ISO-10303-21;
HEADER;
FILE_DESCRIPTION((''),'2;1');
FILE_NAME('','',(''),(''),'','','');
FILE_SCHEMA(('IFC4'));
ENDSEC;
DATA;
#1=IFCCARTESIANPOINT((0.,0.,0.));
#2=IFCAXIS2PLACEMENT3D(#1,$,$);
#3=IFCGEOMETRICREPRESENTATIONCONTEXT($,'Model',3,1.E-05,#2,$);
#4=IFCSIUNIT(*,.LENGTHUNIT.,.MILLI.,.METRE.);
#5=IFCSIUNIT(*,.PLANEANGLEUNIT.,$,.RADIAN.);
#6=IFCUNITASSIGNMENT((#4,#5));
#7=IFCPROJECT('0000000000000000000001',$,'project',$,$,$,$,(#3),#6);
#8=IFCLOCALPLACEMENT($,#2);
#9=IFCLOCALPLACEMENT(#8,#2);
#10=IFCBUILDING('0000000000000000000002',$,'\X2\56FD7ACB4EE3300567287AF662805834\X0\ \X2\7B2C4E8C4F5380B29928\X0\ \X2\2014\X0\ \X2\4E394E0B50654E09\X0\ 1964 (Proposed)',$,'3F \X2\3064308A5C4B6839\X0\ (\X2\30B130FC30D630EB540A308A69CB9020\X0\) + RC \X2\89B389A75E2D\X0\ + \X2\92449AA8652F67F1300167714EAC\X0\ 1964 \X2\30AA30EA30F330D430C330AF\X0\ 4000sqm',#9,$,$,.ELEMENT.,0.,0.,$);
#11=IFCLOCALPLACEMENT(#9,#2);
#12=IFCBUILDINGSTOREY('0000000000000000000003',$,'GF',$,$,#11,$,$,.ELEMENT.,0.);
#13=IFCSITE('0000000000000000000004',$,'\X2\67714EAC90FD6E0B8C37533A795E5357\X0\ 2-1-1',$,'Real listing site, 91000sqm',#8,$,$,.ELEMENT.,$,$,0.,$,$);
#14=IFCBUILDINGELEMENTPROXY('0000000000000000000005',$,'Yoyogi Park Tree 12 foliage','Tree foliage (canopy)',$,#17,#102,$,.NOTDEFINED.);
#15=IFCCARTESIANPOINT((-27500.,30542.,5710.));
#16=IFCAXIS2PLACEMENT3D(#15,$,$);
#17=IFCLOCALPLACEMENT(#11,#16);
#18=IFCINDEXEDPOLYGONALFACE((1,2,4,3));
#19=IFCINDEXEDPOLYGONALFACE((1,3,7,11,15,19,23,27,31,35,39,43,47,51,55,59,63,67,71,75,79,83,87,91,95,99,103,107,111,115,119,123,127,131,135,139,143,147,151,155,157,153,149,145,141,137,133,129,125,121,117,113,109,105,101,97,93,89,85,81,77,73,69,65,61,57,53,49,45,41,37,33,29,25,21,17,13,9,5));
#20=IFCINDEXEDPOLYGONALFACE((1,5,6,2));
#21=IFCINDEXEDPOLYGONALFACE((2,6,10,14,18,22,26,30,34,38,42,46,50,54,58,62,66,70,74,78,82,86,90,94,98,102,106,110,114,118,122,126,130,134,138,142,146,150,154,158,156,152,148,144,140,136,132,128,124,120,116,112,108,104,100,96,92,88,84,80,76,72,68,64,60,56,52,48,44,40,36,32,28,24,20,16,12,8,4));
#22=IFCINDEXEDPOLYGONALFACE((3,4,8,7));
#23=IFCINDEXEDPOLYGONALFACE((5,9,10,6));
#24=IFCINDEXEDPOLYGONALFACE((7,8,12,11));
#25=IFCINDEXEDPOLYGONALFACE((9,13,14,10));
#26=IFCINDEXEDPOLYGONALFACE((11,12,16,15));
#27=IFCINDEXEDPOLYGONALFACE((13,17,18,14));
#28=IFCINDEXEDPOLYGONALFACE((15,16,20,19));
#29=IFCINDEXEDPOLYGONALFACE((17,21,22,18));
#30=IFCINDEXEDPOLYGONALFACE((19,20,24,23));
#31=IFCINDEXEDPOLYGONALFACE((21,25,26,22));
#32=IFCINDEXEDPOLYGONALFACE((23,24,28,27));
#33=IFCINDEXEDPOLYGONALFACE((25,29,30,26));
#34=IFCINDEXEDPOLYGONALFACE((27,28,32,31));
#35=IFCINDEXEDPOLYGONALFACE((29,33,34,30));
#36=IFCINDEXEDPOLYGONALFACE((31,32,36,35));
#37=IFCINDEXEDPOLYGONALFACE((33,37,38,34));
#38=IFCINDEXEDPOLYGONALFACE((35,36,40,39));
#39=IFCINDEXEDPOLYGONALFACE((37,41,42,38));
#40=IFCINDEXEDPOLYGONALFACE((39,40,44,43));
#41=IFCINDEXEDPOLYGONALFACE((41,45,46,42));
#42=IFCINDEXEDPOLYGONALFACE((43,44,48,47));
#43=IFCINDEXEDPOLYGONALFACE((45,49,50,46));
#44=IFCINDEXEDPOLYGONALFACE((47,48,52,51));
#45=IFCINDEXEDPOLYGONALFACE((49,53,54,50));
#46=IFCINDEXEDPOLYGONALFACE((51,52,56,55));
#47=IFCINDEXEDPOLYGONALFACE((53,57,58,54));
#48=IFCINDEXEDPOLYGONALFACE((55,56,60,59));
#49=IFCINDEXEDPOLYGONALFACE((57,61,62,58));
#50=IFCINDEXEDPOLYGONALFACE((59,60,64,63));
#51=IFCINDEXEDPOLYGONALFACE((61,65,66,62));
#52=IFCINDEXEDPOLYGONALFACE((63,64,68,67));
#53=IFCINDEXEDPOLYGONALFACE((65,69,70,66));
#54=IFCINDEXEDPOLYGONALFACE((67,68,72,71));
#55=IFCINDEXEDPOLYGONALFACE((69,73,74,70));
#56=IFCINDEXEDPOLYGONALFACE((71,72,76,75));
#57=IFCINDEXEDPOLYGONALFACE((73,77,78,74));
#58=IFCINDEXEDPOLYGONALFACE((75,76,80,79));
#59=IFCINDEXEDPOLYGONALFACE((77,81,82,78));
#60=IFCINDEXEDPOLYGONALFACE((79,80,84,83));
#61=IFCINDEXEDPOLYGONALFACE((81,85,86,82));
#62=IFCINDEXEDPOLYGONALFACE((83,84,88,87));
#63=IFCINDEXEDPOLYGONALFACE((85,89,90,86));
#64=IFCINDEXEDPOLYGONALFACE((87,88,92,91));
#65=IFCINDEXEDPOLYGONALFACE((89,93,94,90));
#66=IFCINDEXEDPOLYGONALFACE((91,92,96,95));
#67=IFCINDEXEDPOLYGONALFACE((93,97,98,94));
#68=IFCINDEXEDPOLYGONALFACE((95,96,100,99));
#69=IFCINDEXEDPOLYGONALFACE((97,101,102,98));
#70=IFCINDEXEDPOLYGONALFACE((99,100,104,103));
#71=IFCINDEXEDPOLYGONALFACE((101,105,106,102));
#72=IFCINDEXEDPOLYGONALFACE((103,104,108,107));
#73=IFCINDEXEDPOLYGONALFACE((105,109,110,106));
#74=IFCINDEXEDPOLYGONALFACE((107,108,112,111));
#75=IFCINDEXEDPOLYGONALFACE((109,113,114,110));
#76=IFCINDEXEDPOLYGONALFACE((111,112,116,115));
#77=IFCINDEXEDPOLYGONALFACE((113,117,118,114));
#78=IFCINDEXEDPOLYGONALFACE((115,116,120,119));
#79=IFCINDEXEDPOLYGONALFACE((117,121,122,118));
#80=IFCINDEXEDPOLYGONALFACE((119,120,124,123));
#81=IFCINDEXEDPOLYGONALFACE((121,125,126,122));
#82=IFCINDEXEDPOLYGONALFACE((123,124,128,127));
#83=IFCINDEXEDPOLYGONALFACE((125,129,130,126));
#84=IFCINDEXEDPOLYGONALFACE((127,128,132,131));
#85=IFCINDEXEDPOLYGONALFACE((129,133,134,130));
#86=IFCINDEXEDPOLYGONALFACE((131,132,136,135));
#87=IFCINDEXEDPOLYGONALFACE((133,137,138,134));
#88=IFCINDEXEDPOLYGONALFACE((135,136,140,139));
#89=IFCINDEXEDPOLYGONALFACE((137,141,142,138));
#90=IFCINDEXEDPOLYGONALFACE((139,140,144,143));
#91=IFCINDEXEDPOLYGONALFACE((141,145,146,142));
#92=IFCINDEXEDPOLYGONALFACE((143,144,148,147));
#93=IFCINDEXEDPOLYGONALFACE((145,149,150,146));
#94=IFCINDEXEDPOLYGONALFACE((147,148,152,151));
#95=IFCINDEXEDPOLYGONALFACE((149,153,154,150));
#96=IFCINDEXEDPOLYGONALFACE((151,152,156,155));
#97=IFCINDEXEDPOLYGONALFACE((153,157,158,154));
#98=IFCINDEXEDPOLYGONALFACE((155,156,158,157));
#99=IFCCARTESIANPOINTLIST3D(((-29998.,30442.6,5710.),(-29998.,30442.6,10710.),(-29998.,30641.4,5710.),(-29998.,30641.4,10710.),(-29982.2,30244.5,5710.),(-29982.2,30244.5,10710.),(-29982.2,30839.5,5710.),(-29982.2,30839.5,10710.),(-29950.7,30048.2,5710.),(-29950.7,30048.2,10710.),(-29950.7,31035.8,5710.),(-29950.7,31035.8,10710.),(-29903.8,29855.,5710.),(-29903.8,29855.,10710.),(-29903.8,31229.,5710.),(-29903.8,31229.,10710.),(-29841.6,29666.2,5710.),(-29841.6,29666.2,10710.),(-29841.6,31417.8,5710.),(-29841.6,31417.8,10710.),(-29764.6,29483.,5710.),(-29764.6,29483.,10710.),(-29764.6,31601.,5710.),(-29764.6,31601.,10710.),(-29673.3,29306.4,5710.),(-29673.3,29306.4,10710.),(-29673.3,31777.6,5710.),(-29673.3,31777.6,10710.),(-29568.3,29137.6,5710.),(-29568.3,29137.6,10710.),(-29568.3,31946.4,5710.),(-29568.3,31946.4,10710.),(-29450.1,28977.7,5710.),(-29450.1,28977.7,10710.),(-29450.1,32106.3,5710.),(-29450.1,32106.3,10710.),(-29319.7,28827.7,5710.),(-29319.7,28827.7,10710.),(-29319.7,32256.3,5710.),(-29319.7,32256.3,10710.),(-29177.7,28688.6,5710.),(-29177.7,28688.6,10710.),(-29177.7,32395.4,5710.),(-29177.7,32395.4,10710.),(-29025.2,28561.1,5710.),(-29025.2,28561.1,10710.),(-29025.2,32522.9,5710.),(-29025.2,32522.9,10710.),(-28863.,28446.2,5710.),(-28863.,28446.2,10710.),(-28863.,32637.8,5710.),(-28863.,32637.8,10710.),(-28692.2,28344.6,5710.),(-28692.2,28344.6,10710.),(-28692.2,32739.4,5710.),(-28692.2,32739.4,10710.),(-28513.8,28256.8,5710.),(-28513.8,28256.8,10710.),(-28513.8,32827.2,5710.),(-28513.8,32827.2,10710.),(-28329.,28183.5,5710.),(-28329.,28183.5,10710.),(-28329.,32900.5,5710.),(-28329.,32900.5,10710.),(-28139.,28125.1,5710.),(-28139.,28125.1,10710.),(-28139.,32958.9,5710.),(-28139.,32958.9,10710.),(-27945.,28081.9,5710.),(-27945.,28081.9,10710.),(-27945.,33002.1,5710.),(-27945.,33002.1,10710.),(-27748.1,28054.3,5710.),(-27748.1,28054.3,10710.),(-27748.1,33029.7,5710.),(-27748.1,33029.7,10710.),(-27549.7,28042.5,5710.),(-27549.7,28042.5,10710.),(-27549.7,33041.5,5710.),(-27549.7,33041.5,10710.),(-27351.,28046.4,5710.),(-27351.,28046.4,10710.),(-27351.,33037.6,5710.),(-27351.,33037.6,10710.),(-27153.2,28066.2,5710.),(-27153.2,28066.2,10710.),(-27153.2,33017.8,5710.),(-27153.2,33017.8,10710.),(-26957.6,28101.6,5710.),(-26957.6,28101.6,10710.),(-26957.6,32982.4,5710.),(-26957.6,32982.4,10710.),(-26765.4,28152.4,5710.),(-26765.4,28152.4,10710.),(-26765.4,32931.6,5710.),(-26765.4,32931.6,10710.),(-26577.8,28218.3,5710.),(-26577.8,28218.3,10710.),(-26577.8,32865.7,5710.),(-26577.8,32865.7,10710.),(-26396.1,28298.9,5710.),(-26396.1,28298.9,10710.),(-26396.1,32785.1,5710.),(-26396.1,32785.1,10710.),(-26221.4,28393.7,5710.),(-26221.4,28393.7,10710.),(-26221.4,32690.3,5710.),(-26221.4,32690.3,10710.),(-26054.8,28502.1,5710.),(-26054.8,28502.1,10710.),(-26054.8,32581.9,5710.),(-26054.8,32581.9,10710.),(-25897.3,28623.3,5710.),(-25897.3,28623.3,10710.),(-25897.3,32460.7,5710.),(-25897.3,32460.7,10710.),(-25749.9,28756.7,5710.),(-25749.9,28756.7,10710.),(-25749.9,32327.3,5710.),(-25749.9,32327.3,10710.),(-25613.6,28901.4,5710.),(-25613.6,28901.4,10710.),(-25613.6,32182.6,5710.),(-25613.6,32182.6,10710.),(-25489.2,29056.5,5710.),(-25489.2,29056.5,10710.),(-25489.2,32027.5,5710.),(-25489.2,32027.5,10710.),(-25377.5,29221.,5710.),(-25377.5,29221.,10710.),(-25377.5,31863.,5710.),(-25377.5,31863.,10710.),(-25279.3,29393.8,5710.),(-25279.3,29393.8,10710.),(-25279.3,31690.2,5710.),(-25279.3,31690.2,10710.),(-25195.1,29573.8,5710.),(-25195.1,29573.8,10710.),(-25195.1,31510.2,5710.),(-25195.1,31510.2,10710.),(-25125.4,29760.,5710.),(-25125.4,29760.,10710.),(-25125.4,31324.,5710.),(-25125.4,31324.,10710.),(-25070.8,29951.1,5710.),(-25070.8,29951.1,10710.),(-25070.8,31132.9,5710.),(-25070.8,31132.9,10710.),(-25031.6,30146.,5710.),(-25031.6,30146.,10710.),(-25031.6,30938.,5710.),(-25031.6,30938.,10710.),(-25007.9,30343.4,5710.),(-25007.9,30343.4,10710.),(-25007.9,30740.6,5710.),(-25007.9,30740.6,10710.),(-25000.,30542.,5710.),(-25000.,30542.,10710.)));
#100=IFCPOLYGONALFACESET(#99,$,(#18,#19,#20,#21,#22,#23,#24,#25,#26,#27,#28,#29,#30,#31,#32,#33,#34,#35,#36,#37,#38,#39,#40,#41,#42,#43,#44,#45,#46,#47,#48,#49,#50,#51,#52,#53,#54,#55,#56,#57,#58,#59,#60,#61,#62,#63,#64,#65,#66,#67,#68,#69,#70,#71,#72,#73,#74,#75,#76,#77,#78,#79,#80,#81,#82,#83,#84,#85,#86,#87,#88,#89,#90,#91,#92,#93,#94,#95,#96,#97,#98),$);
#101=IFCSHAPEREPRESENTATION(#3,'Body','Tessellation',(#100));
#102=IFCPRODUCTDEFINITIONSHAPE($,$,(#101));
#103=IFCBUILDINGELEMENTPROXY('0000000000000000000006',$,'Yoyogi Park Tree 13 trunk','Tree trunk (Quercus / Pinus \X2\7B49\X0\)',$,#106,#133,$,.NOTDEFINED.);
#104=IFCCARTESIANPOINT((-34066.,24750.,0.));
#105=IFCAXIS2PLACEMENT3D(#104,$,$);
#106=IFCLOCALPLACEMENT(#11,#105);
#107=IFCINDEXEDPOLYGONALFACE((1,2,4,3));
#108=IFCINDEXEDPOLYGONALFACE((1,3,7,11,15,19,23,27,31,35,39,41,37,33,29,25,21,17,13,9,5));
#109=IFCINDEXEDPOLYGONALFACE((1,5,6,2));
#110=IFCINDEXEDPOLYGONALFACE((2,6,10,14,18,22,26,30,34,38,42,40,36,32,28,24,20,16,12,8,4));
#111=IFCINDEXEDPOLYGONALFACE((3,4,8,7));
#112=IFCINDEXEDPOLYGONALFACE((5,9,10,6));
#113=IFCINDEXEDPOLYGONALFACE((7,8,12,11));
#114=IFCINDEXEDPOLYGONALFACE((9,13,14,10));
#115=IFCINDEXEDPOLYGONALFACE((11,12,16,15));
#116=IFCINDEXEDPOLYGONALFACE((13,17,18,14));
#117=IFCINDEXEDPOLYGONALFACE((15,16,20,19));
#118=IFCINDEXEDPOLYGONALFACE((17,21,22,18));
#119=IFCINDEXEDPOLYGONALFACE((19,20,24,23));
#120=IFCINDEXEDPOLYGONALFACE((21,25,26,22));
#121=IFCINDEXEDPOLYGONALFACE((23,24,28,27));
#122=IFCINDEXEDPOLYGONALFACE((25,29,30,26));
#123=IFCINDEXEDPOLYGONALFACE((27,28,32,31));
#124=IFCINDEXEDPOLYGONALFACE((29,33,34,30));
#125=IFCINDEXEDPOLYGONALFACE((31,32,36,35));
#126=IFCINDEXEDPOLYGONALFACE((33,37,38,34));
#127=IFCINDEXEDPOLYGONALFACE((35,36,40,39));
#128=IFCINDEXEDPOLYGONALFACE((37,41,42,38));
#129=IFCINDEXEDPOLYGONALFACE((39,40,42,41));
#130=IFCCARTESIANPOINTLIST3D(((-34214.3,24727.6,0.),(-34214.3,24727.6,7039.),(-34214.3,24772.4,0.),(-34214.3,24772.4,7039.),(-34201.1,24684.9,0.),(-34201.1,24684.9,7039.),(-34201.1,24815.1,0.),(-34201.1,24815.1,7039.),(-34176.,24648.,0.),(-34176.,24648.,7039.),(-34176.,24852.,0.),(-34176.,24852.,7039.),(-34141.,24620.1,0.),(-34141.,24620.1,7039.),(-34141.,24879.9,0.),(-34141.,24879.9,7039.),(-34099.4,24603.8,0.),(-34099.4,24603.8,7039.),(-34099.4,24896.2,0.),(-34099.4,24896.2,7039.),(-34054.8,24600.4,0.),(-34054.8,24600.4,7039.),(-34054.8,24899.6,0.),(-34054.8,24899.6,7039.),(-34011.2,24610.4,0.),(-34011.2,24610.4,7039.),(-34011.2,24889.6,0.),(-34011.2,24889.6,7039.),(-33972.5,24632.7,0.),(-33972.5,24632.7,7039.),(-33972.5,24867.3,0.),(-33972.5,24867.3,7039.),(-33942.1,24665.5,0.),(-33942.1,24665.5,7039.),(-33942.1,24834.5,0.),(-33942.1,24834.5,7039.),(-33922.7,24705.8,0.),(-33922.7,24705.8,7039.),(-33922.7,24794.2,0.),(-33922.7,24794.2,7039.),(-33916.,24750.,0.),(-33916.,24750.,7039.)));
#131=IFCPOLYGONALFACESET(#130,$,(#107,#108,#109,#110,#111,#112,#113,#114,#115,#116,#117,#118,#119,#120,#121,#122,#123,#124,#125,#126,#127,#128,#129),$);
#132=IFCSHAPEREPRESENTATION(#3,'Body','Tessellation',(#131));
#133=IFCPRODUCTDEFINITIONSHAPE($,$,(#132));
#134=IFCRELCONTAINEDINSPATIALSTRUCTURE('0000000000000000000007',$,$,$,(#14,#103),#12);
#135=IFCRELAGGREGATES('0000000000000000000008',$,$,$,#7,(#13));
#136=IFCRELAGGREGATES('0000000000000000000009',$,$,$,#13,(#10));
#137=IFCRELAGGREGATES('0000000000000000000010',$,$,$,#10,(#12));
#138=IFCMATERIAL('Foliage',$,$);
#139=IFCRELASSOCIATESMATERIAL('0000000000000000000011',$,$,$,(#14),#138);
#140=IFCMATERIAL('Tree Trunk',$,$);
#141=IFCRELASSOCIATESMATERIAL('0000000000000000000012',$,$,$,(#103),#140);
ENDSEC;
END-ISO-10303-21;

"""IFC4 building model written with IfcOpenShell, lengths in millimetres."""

from ifc_helpers import new_model, si_unit, frame, origin, origin_2d, place, context, project, spatial, circle, extrude, material, element, save


model = new_model("IFC4")

# Units and contexts
model_context = context("Model", 3, precision=1e-05, world=origin())
ifc_project = project(units=[si_unit("LENGTHUNIT", "METRE", prefix="MILLI"), si_unit("PLANEANGLEUNIT", "RADIAN")], contexts=[model_context])

# Site, building, storey
site_placement = place(None, origin())
site = spatial("IfcSite", under=ifc_project, at=site_placement, Name="東京都渋谷区神南 2-1-1", ObjectType="Real listing site, 91000sqm", CompositionType="ELEMENT", RefElevation=0.0)
building_placement = place(site_placement, origin())
building = spatial("IfcBuilding", under=site, at=building_placement, Name="国立代々木競技場 第二体育館 — 丹下健三 1964 (Proposed)", ObjectType="3F つり屋根 (ケーブル吊り構造) + RC 観覧席 + 鉄骨支柱、東京 1964 オリンピック 4000sqm", CompositionType="ELEMENT", ElevationOfRefHeight=0.0, ElevationOfTerrain=0.0)
storey_placement = place(building_placement, origin())
storey = spatial("IfcBuildingStorey", under=building, at=storey_placement, Name="GF", CompositionType="ELEMENT", Elevation=0.0)

# Building element proxies
ifc_material_1 = material(Name="Tree Trunk")
ifc_material_2 = material(Name="Foliage")
proxy_1_placement = place(storey_placement, frame((-27500.0, 30542.0, 5710.0)))
element("IfcBuildingElementProxy", 1, at=proxy_1_placement, inside=storey, material=ifc_material_2, Name="Yoyogi Park Tree 12 foliage", Description="Tree foliage (canopy)", PredefinedType="NOTDEFINED", context=model_context, shape_type="SweptSolid", body=[
    extrude(circle(Radius=2500.0, at=origin_2d()), frame((-27500.0, 30542.0, 5710.0)), (0.0, 0.0, 1.0), 5000.0),
])
proxy_2_placement = place(storey_placement, frame((-34066.0, 24750.0, 0.0)))
element("IfcBuildingElementProxy", 2, at=proxy_2_placement, inside=storey, material=ifc_material_1, Name="Yoyogi Park Tree 13 trunk", Description="Tree trunk (Quercus / Pinus 等)", PredefinedType="NOTDEFINED", context=model_context, shape_type="SweptSolid", body=[
    extrude(circle(Radius=150.0, at=origin_2d()), frame((-34066.0, 24750.0, 0.0)), (0.0, 0.0, 1.0), 7039.0),
])

save(model, "model.ifc")
